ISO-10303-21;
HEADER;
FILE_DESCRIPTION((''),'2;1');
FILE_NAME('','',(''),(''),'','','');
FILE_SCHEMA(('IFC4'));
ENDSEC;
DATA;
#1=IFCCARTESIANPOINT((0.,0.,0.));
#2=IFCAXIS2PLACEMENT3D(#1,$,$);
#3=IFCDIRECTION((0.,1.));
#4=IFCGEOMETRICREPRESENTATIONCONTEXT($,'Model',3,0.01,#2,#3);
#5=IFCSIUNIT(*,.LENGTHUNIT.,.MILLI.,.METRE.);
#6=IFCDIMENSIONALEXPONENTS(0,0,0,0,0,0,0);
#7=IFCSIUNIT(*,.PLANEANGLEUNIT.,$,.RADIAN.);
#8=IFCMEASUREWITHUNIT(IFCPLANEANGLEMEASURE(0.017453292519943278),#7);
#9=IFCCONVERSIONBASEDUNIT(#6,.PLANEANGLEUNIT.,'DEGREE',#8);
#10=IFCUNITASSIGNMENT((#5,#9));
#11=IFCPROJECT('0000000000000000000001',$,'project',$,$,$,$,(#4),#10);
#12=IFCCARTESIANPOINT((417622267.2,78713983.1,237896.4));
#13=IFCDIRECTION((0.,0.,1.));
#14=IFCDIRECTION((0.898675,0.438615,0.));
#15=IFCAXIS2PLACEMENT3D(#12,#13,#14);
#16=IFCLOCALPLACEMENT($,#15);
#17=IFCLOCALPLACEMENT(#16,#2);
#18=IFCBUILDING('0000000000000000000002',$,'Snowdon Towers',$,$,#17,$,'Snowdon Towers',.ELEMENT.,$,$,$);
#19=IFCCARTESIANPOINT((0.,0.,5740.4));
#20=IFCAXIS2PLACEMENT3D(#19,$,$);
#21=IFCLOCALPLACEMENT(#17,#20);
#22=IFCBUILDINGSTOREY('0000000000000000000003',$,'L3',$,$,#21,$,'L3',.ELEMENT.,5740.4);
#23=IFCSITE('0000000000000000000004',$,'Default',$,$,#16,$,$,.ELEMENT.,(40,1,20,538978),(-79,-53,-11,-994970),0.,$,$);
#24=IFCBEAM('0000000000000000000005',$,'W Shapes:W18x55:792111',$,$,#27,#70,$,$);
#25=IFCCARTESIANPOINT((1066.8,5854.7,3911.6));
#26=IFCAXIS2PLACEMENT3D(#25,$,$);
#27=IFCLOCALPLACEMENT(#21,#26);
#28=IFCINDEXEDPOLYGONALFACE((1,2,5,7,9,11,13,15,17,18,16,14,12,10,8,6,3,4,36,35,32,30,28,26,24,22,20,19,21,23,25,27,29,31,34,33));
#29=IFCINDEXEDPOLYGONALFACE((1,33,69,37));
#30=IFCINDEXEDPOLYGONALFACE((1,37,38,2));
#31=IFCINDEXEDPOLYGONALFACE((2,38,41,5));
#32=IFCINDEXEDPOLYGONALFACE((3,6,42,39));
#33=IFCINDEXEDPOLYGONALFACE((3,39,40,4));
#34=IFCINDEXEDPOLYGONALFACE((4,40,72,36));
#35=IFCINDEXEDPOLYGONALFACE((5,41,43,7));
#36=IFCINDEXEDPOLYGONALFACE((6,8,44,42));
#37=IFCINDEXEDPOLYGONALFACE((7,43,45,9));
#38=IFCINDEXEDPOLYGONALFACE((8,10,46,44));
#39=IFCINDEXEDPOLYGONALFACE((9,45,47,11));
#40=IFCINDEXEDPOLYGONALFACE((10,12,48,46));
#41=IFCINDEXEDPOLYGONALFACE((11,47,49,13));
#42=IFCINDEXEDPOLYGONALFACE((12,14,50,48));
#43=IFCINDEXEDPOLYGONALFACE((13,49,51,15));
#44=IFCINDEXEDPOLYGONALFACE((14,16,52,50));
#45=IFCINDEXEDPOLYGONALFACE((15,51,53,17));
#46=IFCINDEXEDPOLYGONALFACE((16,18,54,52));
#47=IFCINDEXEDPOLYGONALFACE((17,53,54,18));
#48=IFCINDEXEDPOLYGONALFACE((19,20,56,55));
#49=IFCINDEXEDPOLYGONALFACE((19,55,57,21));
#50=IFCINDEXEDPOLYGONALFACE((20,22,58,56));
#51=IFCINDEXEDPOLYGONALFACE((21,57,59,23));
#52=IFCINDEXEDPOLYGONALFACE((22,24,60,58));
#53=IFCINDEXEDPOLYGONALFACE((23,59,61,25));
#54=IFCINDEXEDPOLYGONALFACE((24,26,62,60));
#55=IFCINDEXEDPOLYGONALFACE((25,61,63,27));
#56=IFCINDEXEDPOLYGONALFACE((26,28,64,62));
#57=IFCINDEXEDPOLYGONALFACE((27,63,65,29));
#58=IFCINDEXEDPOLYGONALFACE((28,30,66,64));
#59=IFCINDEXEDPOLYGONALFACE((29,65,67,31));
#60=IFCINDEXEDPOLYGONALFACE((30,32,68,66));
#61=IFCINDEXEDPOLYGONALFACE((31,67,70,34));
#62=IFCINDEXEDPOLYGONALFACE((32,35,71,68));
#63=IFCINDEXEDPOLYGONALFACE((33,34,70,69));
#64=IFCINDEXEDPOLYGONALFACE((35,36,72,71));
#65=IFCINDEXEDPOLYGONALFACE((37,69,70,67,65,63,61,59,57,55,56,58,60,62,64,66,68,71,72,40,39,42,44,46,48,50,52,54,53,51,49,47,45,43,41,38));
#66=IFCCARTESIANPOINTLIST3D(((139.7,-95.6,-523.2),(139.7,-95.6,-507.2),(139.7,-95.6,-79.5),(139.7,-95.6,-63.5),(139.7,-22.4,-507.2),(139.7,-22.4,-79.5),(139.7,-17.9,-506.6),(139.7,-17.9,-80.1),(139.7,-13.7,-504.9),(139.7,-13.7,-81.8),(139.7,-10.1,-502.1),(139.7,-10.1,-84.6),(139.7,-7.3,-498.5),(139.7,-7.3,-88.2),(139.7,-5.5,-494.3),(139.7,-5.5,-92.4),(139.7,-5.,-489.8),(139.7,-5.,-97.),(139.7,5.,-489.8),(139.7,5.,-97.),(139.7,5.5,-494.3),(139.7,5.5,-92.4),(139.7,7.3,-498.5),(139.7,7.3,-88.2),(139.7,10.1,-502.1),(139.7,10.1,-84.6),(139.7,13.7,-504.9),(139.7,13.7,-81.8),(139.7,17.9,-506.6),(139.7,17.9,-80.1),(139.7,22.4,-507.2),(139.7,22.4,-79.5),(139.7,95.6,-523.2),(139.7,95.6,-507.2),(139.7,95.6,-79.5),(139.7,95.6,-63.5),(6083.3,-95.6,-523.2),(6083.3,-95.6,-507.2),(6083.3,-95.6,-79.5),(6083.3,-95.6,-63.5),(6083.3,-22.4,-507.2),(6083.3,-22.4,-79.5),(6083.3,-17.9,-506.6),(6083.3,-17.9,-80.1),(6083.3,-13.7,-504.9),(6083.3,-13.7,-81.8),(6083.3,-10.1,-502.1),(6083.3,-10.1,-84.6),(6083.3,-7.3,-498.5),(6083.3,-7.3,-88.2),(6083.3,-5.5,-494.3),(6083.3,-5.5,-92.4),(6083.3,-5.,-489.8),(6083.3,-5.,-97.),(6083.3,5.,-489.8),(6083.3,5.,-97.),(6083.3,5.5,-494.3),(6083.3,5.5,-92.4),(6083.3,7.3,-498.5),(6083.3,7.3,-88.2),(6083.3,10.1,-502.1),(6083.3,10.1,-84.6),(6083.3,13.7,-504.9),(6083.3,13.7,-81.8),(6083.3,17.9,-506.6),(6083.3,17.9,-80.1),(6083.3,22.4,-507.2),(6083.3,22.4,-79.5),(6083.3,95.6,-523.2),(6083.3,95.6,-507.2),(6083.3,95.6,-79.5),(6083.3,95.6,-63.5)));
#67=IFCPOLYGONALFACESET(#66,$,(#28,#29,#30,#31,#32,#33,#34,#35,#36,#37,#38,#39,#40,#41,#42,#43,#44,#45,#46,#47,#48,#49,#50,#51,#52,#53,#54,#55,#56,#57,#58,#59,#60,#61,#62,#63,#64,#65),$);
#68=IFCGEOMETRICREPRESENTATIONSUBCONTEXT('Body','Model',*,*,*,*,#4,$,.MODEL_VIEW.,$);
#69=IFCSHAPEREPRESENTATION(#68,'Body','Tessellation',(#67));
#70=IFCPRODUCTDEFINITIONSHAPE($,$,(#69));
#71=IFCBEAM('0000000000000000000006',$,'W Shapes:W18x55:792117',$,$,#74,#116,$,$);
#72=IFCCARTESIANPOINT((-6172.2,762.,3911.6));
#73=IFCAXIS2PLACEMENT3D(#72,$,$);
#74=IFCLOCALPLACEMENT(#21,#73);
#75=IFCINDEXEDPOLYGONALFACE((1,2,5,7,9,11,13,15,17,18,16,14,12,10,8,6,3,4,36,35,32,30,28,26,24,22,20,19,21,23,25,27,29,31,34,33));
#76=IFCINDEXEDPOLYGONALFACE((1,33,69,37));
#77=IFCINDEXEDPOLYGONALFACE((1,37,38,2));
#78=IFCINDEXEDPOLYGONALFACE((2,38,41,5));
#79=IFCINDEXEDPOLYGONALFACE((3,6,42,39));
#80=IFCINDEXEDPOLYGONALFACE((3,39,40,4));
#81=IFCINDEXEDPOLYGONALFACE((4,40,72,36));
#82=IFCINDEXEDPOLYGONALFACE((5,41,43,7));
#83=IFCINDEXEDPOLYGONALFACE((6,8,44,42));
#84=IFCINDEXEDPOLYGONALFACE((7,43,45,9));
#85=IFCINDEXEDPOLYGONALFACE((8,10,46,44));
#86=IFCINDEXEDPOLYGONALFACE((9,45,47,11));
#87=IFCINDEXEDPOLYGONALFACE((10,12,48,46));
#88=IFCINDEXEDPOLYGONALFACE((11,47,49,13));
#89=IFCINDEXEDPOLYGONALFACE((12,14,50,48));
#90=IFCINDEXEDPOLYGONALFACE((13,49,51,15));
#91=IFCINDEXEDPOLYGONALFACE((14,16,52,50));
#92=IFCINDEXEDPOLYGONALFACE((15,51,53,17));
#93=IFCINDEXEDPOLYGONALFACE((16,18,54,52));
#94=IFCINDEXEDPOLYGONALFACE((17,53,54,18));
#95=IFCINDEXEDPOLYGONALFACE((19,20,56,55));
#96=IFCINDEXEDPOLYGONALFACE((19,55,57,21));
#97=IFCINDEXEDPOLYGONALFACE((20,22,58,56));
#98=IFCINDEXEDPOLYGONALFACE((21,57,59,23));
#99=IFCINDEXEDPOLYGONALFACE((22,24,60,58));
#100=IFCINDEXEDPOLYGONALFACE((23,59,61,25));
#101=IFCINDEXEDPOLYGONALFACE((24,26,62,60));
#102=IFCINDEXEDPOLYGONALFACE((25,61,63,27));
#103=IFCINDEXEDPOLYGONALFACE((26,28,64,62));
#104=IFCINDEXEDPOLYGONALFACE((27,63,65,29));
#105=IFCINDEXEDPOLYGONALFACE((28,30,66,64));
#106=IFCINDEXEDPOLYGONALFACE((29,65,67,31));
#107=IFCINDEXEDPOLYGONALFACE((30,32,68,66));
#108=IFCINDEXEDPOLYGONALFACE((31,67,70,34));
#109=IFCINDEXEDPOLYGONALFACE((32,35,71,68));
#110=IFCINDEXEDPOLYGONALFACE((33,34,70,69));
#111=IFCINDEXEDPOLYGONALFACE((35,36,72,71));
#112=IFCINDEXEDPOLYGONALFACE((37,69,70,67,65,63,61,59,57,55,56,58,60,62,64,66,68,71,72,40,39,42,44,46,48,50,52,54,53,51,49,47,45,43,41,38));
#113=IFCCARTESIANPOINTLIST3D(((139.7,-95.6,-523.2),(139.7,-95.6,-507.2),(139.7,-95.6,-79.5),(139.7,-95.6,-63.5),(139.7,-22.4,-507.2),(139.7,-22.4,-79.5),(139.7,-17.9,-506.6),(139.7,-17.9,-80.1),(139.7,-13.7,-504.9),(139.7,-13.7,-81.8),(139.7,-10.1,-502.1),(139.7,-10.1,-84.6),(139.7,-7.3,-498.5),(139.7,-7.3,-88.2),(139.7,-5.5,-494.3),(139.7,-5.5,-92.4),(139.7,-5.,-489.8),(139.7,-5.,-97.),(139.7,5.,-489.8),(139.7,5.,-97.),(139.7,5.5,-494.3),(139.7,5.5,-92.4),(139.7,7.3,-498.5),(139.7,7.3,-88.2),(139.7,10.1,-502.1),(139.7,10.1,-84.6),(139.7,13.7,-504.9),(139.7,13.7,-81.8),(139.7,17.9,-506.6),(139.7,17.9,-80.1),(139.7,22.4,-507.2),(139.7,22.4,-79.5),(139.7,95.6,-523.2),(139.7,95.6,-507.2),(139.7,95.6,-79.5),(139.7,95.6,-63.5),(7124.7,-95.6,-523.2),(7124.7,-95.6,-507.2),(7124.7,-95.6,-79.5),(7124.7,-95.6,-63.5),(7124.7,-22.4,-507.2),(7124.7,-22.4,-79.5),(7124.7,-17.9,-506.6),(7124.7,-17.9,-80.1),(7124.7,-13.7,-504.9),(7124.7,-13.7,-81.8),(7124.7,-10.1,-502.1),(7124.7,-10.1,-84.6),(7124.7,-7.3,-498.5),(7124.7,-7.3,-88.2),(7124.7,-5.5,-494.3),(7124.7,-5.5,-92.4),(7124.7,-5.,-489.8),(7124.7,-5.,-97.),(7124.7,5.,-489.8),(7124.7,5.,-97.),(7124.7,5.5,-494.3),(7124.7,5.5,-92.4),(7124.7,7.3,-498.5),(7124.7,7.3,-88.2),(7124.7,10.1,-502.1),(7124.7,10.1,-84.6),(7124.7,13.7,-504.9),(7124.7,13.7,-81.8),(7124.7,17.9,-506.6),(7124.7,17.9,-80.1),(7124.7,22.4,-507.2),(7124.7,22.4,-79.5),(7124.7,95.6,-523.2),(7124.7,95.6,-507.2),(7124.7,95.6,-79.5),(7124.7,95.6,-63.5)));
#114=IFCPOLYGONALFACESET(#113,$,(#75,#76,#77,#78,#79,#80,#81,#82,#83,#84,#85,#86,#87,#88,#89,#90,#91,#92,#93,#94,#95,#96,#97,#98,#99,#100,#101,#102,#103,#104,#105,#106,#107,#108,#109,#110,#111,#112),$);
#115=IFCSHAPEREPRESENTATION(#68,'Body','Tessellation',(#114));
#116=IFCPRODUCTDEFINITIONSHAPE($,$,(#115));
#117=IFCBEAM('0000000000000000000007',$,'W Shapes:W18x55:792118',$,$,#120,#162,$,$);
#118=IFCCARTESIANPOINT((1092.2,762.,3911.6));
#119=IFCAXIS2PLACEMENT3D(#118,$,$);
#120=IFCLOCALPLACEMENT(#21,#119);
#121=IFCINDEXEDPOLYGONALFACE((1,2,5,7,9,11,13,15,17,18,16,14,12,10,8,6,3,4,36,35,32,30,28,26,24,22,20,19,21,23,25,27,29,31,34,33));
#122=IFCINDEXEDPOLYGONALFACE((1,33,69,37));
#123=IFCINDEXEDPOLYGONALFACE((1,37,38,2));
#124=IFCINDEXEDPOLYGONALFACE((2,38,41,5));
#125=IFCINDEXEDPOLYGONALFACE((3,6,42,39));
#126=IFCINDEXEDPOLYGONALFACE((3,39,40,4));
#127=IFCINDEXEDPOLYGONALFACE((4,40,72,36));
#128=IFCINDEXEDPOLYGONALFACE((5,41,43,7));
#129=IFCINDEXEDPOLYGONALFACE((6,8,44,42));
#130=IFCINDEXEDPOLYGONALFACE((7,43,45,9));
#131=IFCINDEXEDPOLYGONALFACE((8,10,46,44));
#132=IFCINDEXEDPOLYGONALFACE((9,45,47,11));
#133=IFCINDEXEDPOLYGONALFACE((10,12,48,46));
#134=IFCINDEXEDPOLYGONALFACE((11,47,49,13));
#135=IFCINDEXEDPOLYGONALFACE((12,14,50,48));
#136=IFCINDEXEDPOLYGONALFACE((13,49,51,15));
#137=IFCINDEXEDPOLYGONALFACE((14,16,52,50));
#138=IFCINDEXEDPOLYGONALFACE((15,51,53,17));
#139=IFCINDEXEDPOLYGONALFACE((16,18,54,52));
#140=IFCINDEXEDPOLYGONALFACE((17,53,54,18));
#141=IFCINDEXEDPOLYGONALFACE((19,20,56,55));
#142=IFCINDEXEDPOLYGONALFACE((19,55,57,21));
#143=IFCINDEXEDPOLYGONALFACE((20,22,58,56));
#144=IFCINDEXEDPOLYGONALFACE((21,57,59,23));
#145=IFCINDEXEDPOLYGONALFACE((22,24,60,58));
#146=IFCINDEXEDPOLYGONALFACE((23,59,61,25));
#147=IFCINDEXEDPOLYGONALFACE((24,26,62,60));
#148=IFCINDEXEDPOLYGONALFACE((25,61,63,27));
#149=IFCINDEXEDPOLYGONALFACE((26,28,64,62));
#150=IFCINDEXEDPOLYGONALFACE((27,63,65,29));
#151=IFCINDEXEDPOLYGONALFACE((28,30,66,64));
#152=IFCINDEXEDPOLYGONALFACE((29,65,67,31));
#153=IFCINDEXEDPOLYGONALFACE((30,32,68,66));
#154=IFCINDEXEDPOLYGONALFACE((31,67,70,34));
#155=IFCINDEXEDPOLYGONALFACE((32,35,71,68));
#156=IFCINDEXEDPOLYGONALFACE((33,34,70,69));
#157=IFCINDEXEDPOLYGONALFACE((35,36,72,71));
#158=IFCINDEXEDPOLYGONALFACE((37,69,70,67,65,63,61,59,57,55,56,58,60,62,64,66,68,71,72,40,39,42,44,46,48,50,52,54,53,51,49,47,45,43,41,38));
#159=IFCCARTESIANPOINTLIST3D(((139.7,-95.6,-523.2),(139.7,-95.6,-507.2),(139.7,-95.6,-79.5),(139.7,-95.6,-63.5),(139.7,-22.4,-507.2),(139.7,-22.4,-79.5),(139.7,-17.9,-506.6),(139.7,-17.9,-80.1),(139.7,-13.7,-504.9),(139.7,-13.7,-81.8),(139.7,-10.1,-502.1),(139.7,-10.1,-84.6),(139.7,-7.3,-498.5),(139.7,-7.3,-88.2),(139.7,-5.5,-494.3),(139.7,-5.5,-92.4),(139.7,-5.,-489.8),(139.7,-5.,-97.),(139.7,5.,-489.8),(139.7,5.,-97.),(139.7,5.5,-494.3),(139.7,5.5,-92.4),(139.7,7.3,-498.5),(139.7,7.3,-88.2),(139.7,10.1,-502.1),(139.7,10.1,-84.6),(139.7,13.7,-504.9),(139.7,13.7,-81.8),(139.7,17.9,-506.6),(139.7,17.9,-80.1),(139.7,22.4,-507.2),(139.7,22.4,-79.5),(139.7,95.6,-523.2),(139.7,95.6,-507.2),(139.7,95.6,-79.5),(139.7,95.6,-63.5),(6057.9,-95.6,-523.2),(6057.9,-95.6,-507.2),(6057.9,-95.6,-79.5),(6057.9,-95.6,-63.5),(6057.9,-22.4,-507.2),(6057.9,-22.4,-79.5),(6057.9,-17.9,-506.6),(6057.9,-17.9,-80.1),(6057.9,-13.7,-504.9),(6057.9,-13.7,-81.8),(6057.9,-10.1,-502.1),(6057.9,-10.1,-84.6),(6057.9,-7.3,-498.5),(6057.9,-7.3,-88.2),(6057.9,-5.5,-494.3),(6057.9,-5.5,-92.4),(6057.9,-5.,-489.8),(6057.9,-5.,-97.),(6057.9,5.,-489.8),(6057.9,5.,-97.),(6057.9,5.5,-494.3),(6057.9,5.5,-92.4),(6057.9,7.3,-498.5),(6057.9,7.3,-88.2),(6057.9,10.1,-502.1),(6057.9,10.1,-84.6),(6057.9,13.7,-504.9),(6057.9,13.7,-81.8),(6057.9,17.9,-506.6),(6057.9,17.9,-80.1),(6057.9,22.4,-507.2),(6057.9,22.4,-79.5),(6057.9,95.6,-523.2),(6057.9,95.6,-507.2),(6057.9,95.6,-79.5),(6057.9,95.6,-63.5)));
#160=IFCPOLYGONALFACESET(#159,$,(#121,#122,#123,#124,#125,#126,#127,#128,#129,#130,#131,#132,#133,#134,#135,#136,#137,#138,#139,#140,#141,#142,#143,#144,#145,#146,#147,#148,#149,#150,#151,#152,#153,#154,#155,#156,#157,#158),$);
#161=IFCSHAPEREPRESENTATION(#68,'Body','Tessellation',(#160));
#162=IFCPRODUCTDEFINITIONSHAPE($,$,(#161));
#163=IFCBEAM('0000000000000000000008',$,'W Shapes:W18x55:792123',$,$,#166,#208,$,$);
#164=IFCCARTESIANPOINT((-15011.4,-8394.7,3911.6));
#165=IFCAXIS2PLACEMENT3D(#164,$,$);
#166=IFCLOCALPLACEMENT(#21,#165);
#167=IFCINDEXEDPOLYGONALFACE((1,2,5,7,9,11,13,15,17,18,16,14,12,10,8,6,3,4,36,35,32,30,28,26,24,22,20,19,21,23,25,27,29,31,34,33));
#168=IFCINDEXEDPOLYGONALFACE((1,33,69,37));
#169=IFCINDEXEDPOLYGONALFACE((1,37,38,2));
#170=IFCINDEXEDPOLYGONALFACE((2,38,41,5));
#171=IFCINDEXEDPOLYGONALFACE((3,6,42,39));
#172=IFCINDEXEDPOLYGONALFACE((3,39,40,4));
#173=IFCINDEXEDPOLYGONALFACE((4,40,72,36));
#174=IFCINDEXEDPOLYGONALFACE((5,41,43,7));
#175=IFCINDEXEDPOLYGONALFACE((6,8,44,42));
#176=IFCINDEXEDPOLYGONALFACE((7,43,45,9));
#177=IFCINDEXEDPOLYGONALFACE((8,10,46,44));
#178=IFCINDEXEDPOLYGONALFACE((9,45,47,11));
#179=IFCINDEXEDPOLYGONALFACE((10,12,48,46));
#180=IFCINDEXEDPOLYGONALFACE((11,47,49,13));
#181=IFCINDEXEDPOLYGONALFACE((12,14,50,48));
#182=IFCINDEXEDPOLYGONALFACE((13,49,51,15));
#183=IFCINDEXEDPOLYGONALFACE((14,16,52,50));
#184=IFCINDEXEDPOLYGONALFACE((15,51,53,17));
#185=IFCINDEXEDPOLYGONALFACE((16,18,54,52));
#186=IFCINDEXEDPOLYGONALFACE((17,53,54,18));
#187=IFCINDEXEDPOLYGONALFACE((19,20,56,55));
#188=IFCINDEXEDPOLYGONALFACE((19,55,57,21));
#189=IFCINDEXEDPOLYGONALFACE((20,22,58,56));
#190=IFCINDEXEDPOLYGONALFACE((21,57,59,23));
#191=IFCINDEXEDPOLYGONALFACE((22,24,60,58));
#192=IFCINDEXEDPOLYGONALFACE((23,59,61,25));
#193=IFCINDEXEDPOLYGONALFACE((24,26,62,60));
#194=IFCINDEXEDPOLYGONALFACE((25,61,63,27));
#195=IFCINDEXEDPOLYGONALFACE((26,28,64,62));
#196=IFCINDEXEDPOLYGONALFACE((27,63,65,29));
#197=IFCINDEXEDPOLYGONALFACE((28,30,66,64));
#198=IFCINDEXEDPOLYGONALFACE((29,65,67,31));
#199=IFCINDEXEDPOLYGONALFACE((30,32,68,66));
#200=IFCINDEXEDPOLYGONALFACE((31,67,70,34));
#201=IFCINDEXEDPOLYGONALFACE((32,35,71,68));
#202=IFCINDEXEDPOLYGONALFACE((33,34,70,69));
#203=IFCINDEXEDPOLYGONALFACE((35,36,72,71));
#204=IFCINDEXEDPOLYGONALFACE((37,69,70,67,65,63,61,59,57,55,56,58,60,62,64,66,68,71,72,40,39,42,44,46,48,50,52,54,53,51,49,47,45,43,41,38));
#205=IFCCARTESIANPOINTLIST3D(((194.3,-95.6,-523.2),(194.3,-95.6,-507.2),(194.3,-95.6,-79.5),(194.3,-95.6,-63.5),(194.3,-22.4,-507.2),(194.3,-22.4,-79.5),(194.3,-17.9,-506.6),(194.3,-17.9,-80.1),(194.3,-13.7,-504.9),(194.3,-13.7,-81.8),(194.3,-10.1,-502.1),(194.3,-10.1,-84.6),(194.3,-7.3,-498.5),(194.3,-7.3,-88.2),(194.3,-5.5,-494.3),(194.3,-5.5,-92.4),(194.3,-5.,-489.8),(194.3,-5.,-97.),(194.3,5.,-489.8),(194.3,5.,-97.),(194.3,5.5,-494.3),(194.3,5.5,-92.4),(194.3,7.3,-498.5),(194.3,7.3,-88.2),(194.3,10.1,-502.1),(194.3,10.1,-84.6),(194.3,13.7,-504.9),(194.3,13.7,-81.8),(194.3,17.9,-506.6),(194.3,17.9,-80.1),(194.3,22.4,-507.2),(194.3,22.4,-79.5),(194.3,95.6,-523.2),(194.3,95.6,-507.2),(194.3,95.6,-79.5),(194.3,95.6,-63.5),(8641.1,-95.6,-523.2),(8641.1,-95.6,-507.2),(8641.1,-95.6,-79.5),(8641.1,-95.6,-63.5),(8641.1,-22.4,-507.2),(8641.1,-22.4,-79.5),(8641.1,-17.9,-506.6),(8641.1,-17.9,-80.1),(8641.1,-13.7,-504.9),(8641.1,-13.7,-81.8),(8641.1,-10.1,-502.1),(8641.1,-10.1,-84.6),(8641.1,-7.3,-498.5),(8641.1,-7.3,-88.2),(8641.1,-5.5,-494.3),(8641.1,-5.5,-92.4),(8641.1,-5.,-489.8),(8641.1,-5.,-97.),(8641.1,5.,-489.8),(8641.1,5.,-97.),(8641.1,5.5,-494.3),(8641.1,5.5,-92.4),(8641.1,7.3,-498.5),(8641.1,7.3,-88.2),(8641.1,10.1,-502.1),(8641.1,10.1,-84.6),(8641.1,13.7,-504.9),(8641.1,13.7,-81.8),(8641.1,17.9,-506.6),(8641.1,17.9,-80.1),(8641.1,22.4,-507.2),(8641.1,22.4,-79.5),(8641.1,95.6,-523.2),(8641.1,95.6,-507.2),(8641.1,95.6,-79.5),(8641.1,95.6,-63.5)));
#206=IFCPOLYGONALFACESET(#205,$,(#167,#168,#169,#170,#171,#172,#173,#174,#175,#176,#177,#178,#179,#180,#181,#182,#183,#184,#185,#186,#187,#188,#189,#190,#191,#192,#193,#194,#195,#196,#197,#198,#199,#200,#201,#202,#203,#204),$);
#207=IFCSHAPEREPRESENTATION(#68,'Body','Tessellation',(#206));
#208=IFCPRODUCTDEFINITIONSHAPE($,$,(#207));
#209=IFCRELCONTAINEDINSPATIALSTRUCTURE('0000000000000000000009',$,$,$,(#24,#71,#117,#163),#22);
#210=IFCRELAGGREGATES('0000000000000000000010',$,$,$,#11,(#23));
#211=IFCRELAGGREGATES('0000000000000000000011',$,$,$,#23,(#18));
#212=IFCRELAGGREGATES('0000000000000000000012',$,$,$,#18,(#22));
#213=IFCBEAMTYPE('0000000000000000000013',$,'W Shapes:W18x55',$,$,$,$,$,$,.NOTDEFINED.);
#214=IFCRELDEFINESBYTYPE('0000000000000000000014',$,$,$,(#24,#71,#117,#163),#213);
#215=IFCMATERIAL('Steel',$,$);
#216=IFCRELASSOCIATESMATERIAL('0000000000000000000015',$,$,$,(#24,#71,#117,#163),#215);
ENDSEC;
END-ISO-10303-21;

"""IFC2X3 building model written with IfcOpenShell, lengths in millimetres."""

from ifc_helpers import new_model, entity, si_unit, converted_unit, direction, frame, frame_2d, origin, place, context, subcontext, project, spatial, i_section, extrude, material, type_object, element, save


model = new_model("IFC2X3")

# Units and contexts
model_context = context("Model", 3, precision=0.01, world=origin(), true_north=direction((0.0, 1.0)))
body_context = subcontext(model_context, "Body", "Model", "MODEL_VIEW")
ifc_project = project(units=[si_unit("LENGTHUNIT", "METRE", prefix="MILLI"), converted_unit("PLANEANGLEUNIT", "DEGREE", entity("IfcPlaneAngleMeasure", 0.017453292519943278), si_unit("PLANEANGLEUNIT", "RADIAN"), dimensions=[0, 0, 0, 0, 0, 0, 0])], contexts=[model_context])

# Site, building, storey
site_placement = place(None, frame((417622267.2, 78713983.1, 237896.4), z_axis=(0.0, 0.0, 1.0), x_axis=(0.898675, 0.438615, 0.0)))
site = spatial("IfcSite", under=ifc_project, at=site_placement, Name="Default", CompositionType="ELEMENT", RefLatitude=(40, 1, 20, 538978), RefLongitude=(-79, -53, -11, -994970), RefElevation=0.0)
building_placement = place(site_placement, origin())
building = spatial("IfcBuilding", under=site, at=building_placement, Name="Snowdon Towers", LongName="Snowdon Towers", CompositionType="ELEMENT")
storey_placement = place(building_placement, frame((0.0, 0.0, 5740.4)))
storey = spatial("IfcBuildingStorey", under=building, at=storey_placement, Name="L3", LongName="L3", CompositionType="ELEMENT", Elevation=5740.4)

# Shared definitions
ifc_material_1 = material(Name="Steel")

# Beams
beam_type = type_object("IfcBeamType", Name="W Shapes:W18x55", PredefinedType="NOTDEFINED")
beam_1_placement = place(storey_placement, frame((1066.8, 5854.7, 3911.6)))
element("IfcBeam", 1, at=beam_1_placement, inside=storey, type_object=beam_type, material=ifc_material_1, Name="W Shapes:W18x55:792111", context=body_context, shape_type="SweptSolid", body=[
    extrude(i_section(OverallWidth=191.3, OverallDepth=459.7, WebThickness=9.9, FlangeThickness=16.0, FilletRadius=17.5, at=frame_2d((0.0, 0.0), x_axis=(0.0, 1.0))), frame((139.7, 0.0, -293.4), z_axis=(1.0, 0.0, 0.0), x_axis=(0.0, 0.0, -1.0)), (0.0, 0.0, 1.0), 5943.6),
])
beam_2_placement = place(storey_placement, frame((-6172.2, 762.0, 3911.6)))
element("IfcBeam", 2, at=beam_2_placement, inside=storey, type_object=beam_type, material=ifc_material_1, Name="W Shapes:W18x55:792117", context=body_context, shape_type="SweptSolid", body=[
    extrude(i_section(OverallWidth=191.3, OverallDepth=459.7, WebThickness=9.9, FlangeThickness=16.0, FilletRadius=17.5, at=frame_2d((0.0, 0.0), x_axis=(0.0, 1.0))), frame((139.7, 0.0, -293.4), z_axis=(1.0, 0.0, 0.0), x_axis=(0.0, 0.0, -1.0)), (0.0, 0.0, 1.0), 6985.0),
])
beam_3_placement = place(storey_placement, frame((1092.2, 762.0, 3911.6)))
element("IfcBeam", 3, at=beam_3_placement, inside=storey, type_object=beam_type, material=ifc_material_1, Name="W Shapes:W18x55:792118", context=body_context, shape_type="SweptSolid", body=[
    extrude(i_section(OverallWidth=191.3, OverallDepth=459.7, WebThickness=9.9, FlangeThickness=16.0, FilletRadius=17.5, at=frame_2d((0.0, 0.0), x_axis=(0.0, 1.0))), frame((139.7, 0.0, -293.4), z_axis=(1.0, 0.0, 0.0), x_axis=(0.0, 0.0, -1.0)), (0.0, 0.0, 1.0), 5918.2),
])
beam_4_placement = place(storey_placement, frame((-15011.4, -8394.7, 3911.6)))
element("IfcBeam", 4, at=beam_4_placement, inside=storey, type_object=beam_type, material=ifc_material_1, Name="W Shapes:W18x55:792123", context=body_context, shape_type="SweptSolid", body=[
    extrude(i_section(OverallWidth=191.3, OverallDepth=459.7, WebThickness=9.9, FlangeThickness=16.0, FilletRadius=17.5, at=frame_2d((0.0, 0.0), x_axis=(0.0, 1.0))), frame((194.3, 0.0, -293.4), z_axis=(1.0, 0.0, 0.0), x_axis=(0.0, 0.0, -1.0)), (0.0, 0.0, 1.0), 8446.8),
])

save(model, "model.ifc")
